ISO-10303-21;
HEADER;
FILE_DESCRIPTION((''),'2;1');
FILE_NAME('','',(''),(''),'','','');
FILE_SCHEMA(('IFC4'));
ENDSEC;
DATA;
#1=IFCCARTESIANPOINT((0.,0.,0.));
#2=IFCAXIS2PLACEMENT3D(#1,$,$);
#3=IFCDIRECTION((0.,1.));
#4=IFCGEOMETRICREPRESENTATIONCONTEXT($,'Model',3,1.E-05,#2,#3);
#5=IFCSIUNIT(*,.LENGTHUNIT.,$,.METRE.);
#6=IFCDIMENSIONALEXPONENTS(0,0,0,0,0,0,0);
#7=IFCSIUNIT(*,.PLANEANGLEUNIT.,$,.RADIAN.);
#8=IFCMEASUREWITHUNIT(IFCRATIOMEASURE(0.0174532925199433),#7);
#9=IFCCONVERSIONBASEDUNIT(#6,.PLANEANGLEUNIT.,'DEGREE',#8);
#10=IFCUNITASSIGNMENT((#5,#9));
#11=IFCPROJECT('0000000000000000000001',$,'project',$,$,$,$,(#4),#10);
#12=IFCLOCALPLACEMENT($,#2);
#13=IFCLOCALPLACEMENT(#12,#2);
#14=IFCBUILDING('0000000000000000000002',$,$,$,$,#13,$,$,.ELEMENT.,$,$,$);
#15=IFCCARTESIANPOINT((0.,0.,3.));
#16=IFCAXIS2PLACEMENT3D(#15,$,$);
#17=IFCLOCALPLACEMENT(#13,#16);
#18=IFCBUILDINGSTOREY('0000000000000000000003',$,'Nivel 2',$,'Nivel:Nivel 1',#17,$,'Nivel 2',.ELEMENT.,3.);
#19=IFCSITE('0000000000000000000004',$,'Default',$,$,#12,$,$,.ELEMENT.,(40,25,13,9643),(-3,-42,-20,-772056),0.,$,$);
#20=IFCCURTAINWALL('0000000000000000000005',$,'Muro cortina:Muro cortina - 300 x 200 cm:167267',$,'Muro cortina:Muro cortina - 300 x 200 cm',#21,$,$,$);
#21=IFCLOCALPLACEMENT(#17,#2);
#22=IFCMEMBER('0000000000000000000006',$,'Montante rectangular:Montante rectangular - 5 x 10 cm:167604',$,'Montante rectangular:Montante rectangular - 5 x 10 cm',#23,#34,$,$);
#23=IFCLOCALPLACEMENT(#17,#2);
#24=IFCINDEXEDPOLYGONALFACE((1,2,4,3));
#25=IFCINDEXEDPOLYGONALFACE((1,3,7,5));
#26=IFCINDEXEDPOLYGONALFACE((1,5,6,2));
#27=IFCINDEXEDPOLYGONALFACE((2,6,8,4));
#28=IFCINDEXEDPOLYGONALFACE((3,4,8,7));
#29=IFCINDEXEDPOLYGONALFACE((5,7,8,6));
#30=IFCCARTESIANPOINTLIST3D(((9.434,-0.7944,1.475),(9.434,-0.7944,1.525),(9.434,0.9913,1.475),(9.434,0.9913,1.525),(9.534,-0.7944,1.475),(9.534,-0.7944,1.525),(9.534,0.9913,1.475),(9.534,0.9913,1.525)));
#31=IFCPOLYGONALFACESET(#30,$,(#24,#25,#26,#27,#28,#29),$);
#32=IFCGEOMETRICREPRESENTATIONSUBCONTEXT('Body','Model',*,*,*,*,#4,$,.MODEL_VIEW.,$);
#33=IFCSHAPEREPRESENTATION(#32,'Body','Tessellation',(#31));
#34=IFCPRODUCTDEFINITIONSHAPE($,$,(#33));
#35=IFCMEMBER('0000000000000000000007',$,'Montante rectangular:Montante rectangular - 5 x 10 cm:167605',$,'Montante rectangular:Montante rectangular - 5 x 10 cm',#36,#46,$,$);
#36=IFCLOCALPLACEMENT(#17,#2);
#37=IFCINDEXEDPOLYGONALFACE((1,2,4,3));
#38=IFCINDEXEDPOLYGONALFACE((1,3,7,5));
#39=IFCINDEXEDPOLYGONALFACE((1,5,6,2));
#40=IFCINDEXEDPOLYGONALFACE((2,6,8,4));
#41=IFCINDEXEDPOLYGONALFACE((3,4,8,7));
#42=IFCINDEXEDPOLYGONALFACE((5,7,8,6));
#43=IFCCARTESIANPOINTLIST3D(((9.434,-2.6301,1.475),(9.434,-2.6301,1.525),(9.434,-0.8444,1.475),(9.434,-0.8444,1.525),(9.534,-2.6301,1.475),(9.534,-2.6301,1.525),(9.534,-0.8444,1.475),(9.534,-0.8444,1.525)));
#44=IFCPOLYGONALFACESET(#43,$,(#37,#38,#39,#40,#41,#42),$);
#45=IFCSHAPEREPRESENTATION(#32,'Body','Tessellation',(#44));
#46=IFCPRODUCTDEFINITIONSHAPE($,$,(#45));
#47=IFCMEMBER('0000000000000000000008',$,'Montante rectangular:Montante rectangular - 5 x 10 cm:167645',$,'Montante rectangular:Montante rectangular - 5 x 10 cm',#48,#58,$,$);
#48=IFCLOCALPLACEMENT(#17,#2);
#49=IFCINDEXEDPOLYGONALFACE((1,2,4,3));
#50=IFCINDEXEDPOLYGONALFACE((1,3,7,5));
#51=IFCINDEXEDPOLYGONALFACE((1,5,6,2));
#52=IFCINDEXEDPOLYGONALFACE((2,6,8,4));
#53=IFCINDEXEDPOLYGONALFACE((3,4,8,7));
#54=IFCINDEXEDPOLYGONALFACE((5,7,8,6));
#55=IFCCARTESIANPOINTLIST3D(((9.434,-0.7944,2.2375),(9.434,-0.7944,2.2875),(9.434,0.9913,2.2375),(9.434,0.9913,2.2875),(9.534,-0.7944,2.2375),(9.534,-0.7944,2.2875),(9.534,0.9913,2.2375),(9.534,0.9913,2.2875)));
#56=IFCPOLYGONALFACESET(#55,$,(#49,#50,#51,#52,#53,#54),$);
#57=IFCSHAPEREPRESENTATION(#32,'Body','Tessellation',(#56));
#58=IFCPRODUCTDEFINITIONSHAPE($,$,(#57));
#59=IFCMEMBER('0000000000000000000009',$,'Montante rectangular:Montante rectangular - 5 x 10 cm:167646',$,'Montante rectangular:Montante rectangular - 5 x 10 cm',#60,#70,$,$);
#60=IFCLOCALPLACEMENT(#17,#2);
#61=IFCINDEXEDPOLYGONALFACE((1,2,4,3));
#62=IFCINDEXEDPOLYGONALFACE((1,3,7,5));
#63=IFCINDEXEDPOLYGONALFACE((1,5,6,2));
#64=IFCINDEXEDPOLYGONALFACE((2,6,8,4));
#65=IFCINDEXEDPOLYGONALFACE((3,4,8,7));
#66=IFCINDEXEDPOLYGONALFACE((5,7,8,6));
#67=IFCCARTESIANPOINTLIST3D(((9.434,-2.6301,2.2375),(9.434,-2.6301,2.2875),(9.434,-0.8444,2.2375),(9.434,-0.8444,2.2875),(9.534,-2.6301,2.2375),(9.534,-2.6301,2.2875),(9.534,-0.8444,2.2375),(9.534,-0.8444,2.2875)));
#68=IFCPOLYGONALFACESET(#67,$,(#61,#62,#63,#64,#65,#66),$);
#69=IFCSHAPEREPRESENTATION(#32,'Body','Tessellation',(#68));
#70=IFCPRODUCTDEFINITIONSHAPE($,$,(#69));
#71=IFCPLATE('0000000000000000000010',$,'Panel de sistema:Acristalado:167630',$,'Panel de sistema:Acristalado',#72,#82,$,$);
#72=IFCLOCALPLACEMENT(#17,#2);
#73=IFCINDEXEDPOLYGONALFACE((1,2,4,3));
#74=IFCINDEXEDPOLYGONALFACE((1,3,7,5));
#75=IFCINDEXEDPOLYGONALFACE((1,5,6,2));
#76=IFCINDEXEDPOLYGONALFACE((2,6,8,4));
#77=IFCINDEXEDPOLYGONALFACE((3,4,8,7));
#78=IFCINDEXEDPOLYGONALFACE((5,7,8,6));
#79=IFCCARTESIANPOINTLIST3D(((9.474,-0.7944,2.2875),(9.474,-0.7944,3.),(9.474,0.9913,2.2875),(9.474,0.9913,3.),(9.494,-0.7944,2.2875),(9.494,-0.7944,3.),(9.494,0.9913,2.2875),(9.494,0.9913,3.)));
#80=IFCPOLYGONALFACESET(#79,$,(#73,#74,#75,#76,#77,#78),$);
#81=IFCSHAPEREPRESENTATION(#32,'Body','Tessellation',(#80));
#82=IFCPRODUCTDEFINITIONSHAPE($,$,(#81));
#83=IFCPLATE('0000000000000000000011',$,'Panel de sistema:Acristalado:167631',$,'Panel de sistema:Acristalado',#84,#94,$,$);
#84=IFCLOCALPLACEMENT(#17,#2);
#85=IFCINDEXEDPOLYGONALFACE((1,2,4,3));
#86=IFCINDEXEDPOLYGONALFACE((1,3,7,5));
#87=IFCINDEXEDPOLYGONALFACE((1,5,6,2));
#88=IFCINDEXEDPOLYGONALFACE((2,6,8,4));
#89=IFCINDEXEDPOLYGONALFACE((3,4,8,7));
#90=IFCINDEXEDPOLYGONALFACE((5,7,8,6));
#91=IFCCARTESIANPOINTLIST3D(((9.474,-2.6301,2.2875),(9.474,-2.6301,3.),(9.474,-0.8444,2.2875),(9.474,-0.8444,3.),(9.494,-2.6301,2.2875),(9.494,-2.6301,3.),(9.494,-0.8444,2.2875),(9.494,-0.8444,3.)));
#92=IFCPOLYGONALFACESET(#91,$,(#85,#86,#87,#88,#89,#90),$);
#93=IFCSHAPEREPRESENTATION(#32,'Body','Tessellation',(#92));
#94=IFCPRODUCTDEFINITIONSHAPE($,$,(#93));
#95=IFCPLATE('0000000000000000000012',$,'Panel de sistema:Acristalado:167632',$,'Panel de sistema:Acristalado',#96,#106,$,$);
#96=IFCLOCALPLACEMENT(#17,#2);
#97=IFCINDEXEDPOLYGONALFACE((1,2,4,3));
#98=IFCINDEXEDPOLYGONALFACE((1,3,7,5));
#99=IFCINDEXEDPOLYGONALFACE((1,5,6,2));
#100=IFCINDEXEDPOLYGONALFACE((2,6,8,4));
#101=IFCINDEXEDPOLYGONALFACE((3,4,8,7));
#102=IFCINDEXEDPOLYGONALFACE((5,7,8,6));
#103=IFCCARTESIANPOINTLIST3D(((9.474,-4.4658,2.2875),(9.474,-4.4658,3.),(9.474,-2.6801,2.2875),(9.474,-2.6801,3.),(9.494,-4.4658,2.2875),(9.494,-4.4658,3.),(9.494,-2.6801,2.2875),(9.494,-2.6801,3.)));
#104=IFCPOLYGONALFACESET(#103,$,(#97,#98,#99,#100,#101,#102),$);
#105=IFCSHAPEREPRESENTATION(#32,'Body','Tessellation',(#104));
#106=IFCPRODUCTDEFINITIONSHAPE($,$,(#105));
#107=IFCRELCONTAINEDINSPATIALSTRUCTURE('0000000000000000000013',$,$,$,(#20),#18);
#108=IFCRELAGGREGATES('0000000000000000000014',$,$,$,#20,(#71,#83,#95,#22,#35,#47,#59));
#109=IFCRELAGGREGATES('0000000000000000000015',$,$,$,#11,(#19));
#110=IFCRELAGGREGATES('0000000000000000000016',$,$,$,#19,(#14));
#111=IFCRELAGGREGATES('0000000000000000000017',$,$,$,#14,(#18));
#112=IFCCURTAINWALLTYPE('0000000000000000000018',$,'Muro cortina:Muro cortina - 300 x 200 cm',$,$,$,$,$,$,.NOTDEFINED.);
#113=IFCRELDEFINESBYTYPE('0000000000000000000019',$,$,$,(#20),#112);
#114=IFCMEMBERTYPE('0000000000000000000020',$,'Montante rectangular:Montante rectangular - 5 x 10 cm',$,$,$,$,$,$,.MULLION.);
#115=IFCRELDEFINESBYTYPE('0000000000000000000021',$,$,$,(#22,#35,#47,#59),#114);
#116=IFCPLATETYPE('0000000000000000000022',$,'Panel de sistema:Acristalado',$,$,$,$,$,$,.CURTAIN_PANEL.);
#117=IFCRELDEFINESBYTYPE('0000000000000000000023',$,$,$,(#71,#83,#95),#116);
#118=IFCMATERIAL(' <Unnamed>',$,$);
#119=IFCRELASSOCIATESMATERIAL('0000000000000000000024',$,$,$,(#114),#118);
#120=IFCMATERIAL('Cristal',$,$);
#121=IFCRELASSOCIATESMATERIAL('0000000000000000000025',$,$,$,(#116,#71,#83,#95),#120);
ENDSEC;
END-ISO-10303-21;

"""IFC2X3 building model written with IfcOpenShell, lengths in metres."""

from ifc_helpers import new_model, entity, si_unit, converted_unit, direction, frame, origin, origin_2d_with_axis, place, context, subcontext, project, spatial, rectangle, extrude, source, transform, mapped, material, type_object, type_shapes, element, aggregate, save


model = new_model("IFC2X3")

# Units and contexts
model_context = context("Model", 3, precision=1e-05, world=origin(), true_north=direction((0.0, 1.0)))
body_context = subcontext(model_context, "Body", "Model", "MODEL_VIEW")
ifc_project = project(units=[si_unit("LENGTHUNIT", "METRE"), converted_unit("PLANEANGLEUNIT", "DEGREE", entity("IfcRatioMeasure", 0.0174532925199433), si_unit("PLANEANGLEUNIT", "RADIAN"), dimensions=[0, 0, 0, 0, 0, 0, 0])], contexts=[model_context])

# Site, building, storey
site_placement = place(None, origin())
site = spatial("IfcSite", under=ifc_project, at=site_placement, Name="Default", CompositionType="ELEMENT", RefLatitude=(40, 25, 13, 9643), RefLongitude=(-3, -42, -20, -772056), RefElevation=0.0)
building_placement = place(site_placement, origin())
building = spatial("IfcBuilding", under=site, at=building_placement, CompositionType="ELEMENT")
storey_placement = place(building_placement, frame((0.0, 0.0, 3.0)))
storey = spatial("IfcBuildingStorey", under=building, at=storey_placement, Name="Nivel 2", ObjectType="Nivel:Nivel 1", LongName="Nivel 2", CompositionType="ELEMENT", Elevation=3.0)

# Curtain wall, members, plates
curtain_wall_type = type_object("IfcCurtainWallType", Name="Muro cortina:Muro cortina - 300 x 200 cm", PredefinedType="NOTDEFINED")
curtain_wall_placement = place(storey_placement, frame((0.0, 0.0, -3.0)))
curtain_wall = element("IfcCurtainWall", 1, at=curtain_wall_placement, inside=storey, type_object=curtain_wall_type, Name="Muro cortina:Muro cortina - 300 x 200 cm:167267", ObjectType="Muro cortina:Muro cortina - 300 x 200 cm")
ifc_material_1 = material(Name=" <Unnamed>")
member_type_1 = type_object("IfcMemberType", Name="Montante rectangular:Montante rectangular - 5 x 10 cm", PredefinedType="MULLION", material=ifc_material_1)
shared_shape_1 = source(origin(), body_context, "Body", "SweptSolid", [
    extrude(rectangle(XDim=0.1, YDim=0.05, at=origin_2d_with_axis()), frame((0.0, 0.0, -1.7857), z_axis=(0.0, 0.0, 1.0), x_axis=(0.0, -1.0, 0.0)), (0.0, 0.0, 1.0), 1.7857),
])
type_shapes(member_type_1, [shared_shape_1])
member_1_placement = place(storey_placement, frame((9.484, -0.7944, 1.5), z_axis=(0.0, -1.0, 0.0), x_axis=(0.0, 0.0, 1.0)))
member_1 = element("IfcMember", 2, at=member_1_placement, type_object=member_type_1, Name="Montante rectangular:Montante rectangular - 5 x 10 cm:167604", ObjectType="Montante rectangular:Montante rectangular - 5 x 10 cm", context=body_context, shape_type="MappedRepresentation", body=[
    mapped(shared_shape_1, transform((0.0, 0.0, 0.0), scale=1.0)),
])
member_2_placement = place(storey_placement, frame((9.484, -2.6301, 1.5), z_axis=(0.0, -1.0, 0.0), x_axis=(0.0, 0.0, 1.0)))
member_2 = element("IfcMember", 3, at=member_2_placement, type_object=member_type_1, Name="Montante rectangular:Montante rectangular - 5 x 10 cm:167605", ObjectType="Montante rectangular:Montante rectangular - 5 x 10 cm", context=body_context, shape_type="MappedRepresentation", body=[
    mapped(shared_shape_1, transform((0.0, 0.0, 0.0), scale=1.0)),
])
member_3_placement = place(storey_placement, frame((9.484, -0.7944, 2.2625), z_axis=(0.0, -1.0, 0.0), x_axis=(0.0, 0.0, 1.0)))
member_3 = element("IfcMember", 4, at=member_3_placement, type_object=member_type_1, Name="Montante rectangular:Montante rectangular - 5 x 10 cm:167645", ObjectType="Montante rectangular:Montante rectangular - 5 x 10 cm", context=body_context, shape_type="MappedRepresentation", body=[
    mapped(shared_shape_1, transform((0.0, 0.0, 0.0), scale=1.0)),
])
member_4_placement = place(storey_placement, frame((9.484, -2.6301, 2.2625), z_axis=(0.0, -1.0, 0.0), x_axis=(0.0, 0.0, 1.0)))
member_4 = element("IfcMember", 5, at=member_4_placement, type_object=member_type_1, Name="Montante rectangular:Montante rectangular - 5 x 10 cm:167646", ObjectType="Montante rectangular:Montante rectangular - 5 x 10 cm", context=body_context, shape_type="MappedRepresentation", body=[
    mapped(shared_shape_1, transform((0.0, 0.0, 0.0), scale=1.0)),
])
ifc_material_2 = material(Name="Cristal")
plate_type = type_object("IfcPlateType", Name="Panel de sistema:Acristalado", PredefinedType="CURTAIN_PANEL", material=ifc_material_2)
shared_shape_2 = source(origin(), body_context, "Body", "SweptSolid", [
    extrude(rectangle(XDim=0.02, YDim=1.7857, at=origin_2d_with_axis()), frame((0.0, 0.0, 0.0), z_axis=(0.0, 0.0, 1.0), x_axis=(0.0, 1.0, 0.0)), (0.0, 0.0, 1.0), 0.7125),
])
type_shapes(plate_type, [shared_shape_2])
plate_1_placement = place(curtain_wall_placement, frame((9.484, 0.0985, 5.2875), z_axis=(0.0, 0.0, 1.0), x_axis=(0.0, -1.0, 0.0)))
plate_1 = element("IfcPlate", 6, at=plate_1_placement, type_object=plate_type, material=ifc_material_2, Name="Panel de sistema:Acristalado:167630", ObjectType="Panel de sistema:Acristalado", context=body_context, shape_type="MappedRepresentation", body=[
    mapped(shared_shape_2, transform((0.0, 0.0, 0.0), scale=1.0)),
])
plate_2_placement = place(curtain_wall_placement, frame((9.484, -1.7373, 5.2875), z_axis=(0.0, 0.0, 1.0), x_axis=(0.0, -1.0, 0.0)))
plate_2 = element("IfcPlate", 7, at=plate_2_placement, type_object=plate_type, material=ifc_material_2, Name="Panel de sistema:Acristalado:167631", ObjectType="Panel de sistema:Acristalado", context=body_context, shape_type="MappedRepresentation", body=[
    mapped(shared_shape_2, transform((0.0, 0.0, 0.0), scale=1.0)),
])
plate_3_placement = place(curtain_wall_placement, frame((9.484, -3.573, 5.2875), z_axis=(0.0, 0.0, 1.0), x_axis=(0.0, -1.0, 0.0)))
plate_3 = element("IfcPlate", 8, at=plate_3_placement, type_object=plate_type, material=ifc_material_2, Name="Panel de sistema:Acristalado:167632", ObjectType="Panel de sistema:Acristalado", context=body_context, shape_type="MappedRepresentation", body=[
    mapped(shared_shape_2, transform((0.0, 0.0, 0.0), scale=1.0)),
])
aggregate(curtain_wall, [plate_1, plate_2, plate_3, member_1, member_2, member_3, member_4])

save(model, "model.ifc")
